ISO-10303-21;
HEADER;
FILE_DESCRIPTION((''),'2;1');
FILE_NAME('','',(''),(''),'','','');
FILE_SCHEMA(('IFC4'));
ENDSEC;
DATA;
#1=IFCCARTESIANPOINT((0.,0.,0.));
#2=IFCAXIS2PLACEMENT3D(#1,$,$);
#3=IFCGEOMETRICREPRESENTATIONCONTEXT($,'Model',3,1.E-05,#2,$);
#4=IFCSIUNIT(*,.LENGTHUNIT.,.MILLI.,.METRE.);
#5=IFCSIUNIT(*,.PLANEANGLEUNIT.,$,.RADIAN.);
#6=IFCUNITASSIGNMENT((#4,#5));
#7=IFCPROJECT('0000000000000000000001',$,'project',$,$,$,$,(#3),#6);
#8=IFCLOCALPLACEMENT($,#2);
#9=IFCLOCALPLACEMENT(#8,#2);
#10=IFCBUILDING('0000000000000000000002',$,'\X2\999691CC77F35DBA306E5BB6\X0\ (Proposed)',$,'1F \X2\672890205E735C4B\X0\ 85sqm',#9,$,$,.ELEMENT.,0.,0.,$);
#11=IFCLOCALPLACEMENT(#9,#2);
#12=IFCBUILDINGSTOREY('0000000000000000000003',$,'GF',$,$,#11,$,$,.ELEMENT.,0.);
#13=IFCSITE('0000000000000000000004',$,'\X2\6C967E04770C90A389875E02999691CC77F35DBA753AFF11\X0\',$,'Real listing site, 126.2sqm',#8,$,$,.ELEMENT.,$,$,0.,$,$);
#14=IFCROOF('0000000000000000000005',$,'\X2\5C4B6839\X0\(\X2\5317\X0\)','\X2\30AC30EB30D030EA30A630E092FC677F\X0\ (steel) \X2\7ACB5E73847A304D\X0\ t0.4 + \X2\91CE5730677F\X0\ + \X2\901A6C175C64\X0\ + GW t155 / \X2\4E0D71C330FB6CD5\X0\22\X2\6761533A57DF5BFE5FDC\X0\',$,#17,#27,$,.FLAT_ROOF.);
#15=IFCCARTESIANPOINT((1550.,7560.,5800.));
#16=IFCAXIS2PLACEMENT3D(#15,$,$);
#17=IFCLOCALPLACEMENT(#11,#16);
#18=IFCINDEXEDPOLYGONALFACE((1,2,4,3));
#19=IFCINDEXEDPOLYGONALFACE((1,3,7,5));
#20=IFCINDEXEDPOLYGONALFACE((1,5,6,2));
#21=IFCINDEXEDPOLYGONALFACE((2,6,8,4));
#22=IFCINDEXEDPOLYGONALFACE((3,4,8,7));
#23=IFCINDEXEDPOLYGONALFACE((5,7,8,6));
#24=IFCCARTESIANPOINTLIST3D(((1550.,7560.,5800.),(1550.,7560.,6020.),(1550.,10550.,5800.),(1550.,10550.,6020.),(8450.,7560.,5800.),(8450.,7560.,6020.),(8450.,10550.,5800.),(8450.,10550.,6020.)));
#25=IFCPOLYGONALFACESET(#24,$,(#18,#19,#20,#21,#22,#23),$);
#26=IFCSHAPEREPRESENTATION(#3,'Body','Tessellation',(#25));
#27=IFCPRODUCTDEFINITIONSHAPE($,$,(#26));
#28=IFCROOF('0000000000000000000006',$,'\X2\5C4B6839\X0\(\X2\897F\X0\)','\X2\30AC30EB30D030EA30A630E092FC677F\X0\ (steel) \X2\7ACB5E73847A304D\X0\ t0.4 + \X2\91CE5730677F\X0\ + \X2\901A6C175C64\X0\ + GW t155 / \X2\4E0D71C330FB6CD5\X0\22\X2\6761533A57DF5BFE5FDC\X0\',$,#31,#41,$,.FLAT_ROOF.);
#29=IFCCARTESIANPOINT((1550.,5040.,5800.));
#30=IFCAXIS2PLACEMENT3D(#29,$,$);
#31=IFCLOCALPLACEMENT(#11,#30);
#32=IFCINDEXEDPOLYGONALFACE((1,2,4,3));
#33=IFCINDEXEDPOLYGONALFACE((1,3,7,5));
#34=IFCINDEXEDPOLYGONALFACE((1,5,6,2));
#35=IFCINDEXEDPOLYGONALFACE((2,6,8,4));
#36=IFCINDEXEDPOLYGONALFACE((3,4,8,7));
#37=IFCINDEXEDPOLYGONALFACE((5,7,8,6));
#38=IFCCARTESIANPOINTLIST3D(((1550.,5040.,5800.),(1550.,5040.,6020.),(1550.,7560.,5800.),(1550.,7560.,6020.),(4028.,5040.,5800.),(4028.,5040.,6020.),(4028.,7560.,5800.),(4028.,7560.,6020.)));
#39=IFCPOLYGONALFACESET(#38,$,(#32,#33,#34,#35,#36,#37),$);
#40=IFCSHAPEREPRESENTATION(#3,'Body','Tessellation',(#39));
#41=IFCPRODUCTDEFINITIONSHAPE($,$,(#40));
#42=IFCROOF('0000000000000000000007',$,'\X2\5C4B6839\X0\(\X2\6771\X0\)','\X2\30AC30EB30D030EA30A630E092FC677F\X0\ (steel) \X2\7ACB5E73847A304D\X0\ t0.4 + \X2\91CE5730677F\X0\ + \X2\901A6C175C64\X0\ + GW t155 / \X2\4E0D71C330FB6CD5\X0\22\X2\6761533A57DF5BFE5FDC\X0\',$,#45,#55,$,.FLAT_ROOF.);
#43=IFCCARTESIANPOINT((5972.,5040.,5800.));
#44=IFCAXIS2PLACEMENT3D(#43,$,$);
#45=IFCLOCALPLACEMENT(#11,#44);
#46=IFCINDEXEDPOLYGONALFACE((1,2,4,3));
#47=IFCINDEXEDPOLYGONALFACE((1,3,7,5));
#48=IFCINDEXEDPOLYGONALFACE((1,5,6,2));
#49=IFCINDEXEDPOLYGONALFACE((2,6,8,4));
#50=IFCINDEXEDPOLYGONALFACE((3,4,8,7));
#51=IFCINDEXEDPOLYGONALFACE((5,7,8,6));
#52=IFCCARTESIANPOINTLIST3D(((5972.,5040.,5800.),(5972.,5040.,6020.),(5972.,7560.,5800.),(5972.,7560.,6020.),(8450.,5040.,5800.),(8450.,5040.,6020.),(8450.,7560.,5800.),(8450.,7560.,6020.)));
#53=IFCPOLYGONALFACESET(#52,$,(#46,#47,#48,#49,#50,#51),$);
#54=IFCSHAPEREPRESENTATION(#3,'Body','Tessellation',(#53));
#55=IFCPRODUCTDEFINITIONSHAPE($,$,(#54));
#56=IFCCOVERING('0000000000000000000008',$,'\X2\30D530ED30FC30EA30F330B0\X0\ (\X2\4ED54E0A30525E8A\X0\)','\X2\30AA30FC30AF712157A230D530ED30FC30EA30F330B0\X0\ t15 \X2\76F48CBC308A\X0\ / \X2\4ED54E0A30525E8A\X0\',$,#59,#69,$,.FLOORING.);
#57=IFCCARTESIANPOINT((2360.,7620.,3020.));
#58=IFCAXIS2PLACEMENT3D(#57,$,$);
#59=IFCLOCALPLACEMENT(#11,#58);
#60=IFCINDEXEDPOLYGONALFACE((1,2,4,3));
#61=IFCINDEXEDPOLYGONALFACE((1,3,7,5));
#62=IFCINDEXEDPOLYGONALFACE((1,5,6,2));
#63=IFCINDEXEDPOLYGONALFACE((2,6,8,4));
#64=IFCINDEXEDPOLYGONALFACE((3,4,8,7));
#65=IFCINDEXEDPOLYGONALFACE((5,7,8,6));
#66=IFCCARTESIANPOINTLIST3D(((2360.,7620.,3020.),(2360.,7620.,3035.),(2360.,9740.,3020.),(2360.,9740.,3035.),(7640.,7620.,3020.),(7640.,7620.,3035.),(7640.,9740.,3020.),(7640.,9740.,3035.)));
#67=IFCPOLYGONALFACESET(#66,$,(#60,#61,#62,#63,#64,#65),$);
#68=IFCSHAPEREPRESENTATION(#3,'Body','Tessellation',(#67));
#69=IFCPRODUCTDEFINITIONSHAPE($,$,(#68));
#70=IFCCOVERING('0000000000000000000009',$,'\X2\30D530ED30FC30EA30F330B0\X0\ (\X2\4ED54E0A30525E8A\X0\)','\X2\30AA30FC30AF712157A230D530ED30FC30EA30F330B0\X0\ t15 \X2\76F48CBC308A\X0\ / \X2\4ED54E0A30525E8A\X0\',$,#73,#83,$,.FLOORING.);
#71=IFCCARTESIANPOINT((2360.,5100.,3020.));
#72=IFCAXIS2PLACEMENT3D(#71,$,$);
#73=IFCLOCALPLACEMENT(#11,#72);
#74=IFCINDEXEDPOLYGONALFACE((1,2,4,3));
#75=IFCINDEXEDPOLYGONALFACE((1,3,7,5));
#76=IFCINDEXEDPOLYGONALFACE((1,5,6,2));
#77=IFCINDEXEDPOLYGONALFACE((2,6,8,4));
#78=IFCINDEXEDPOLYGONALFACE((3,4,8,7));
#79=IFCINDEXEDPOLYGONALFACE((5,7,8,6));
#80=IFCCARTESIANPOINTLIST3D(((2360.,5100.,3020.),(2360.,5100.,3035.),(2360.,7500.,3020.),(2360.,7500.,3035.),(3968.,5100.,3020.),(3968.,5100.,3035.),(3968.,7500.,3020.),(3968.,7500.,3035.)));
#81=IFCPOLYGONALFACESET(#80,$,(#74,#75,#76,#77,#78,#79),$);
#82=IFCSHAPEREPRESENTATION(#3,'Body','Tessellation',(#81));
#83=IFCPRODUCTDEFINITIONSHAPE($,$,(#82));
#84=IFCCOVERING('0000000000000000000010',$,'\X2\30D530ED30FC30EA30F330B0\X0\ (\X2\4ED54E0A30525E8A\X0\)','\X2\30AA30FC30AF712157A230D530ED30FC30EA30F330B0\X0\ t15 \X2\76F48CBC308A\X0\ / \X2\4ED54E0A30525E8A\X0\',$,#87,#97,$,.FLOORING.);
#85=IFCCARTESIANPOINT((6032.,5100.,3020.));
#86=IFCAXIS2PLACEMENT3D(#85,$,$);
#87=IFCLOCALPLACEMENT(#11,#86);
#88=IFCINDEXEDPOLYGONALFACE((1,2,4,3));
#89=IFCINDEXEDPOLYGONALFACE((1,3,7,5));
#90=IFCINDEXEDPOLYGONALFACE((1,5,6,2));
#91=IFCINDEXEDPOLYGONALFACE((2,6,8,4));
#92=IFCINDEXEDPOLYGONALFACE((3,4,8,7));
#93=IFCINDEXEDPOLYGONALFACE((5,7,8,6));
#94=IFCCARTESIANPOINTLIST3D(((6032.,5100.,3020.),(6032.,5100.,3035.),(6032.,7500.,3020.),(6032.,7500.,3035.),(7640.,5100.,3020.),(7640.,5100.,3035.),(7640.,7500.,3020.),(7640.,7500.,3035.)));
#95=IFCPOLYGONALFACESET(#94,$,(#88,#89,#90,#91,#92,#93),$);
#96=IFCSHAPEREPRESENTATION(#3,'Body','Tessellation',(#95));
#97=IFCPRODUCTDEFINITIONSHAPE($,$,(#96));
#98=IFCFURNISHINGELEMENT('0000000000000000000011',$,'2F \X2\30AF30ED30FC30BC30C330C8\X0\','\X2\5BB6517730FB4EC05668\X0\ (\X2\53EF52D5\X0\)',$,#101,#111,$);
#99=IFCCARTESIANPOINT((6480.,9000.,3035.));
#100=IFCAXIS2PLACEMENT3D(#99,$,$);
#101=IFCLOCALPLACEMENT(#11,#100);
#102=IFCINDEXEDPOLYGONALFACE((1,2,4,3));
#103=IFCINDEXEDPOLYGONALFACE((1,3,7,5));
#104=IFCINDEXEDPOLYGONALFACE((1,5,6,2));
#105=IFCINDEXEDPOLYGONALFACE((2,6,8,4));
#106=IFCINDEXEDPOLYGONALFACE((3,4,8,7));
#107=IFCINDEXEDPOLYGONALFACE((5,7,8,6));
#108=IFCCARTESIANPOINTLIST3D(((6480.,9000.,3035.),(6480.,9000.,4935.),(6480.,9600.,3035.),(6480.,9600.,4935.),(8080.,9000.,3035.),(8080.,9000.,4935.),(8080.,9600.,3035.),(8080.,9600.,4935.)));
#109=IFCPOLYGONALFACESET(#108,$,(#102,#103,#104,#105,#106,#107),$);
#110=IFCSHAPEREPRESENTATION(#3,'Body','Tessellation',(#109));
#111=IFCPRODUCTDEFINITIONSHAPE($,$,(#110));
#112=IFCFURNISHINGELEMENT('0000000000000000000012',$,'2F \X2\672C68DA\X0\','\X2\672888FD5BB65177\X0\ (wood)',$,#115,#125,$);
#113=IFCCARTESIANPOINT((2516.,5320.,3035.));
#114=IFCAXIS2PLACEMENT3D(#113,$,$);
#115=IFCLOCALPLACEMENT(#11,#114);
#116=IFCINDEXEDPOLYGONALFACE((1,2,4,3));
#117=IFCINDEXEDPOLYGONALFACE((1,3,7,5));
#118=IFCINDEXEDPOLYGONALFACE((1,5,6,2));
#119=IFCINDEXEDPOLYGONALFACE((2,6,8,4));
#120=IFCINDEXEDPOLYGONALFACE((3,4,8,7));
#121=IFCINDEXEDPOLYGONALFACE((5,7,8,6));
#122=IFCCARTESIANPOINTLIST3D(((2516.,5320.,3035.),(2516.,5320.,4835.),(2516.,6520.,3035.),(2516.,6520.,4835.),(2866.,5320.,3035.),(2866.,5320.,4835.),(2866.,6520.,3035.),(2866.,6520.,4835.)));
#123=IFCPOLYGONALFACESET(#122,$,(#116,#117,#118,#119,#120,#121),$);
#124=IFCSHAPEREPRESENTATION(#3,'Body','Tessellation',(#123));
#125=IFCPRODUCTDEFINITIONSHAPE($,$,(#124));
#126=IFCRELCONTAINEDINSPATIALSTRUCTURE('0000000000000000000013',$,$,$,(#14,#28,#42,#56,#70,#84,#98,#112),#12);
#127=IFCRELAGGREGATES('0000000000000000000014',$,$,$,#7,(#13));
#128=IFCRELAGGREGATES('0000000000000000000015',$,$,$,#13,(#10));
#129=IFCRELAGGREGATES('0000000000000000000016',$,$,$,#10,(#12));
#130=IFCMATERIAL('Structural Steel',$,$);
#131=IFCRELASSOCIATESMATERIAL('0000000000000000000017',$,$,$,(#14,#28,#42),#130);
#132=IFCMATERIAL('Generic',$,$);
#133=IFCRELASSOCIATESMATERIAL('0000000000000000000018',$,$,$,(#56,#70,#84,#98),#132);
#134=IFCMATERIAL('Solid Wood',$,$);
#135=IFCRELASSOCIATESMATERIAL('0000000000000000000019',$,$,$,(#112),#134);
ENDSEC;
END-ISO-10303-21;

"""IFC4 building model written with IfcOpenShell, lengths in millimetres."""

from ifc_helpers import new_model, si_unit, frame, frame_2d, origin, place, context, project, spatial, rectangle, extrude, material, element, save


model = new_model("IFC4")

# Units and contexts
model_context = context("Model", 3, precision=1e-05, world=origin())
ifc_project = project(units=[si_unit("LENGTHUNIT", "METRE", prefix="MILLI"), si_unit("PLANEANGLEUNIT", "RADIAN")], contexts=[model_context])

# Site, building, storey
site_placement = place(None, origin())
site = spatial("IfcSite", under=ifc_project, at=site_placement, Name="沖縄県那覇市首里石嶺町１", ObjectType="Real listing site, 126.2sqm", CompositionType="ELEMENT", RefElevation=0.0)
building_placement = place(site_placement, origin())
building = spatial("IfcBuilding", under=site, at=building_placement, Name="首里石嶺の家 (Proposed)", ObjectType="1F 木造平屋 85sqm", CompositionType="ELEMENT", ElevationOfRefHeight=0.0, ElevationOfTerrain=0.0)
storey_placement = place(building_placement, origin())
storey = spatial("IfcBuildingStorey", under=building, at=storey_placement, Name="GF", CompositionType="ELEMENT", Elevation=0.0)

# Shared definitions
ifc_material_1 = material(Name="Solid Wood")

# Shared definitions
ifc_material_2 = material(Name="Generic")

# Roofs
ifc_material_3 = material(Name="Structural Steel")
for number, where, name in (
    (1, (1550.0, 7560.0, 5800.0), "屋根(北)"),
):
    element("IfcRoof", number, at=place(storey_placement, frame(where)), inside=storey, material=ifc_material_3, Name=name, Description="ガルバリウム鋼板 (steel) 立平葺き t0.4 + 野地板 + 通気層 + GW t155 / 不燃・法22条区域対応", PredefinedType="FLAT_ROOF", context=model_context, shape_type="SweptSolid", body=[
        extrude(rectangle(XDim=6900.0, YDim=2990.0, at=frame_2d((3450.0, 1495.0))), frame((1550.0, 7560.0, 5800.0)), (0.0, 0.0, 1.0), 220.0),
    ])
roof_1_placement = place(storey_placement, frame((1550.0, 5040.0, 5800.0)))
element("IfcRoof", 2, at=roof_1_placement, inside=storey, material=ifc_material_3, Name="屋根(西)", Description="ガルバリウム鋼板 (steel) 立平葺き t0.4 + 野地板 + 通気層 + GW t155 / 不燃・法22条区域対応", PredefinedType="FLAT_ROOF", context=model_context, shape_type="SweptSolid", body=[
    extrude(rectangle(XDim=2478.0, YDim=2520.0, at=frame_2d((1239.0, 1260.0))), frame((1550.0, 5040.0, 5800.0)), (0.0, 0.0, 1.0), 220.0),
])
roof_2_placement = place(storey_placement, frame((5972.0, 5040.0, 5800.0)))
element("IfcRoof", 3, at=roof_2_placement, inside=storey, material=ifc_material_3, Name="屋根(東)", Description="ガルバリウム鋼板 (steel) 立平葺き t0.4 + 野地板 + 通気層 + GW t155 / 不燃・法22条区域対応", PredefinedType="FLAT_ROOF", context=model_context, shape_type="SweptSolid", body=[
    extrude(rectangle(XDim=2478.0, YDim=2520.0, at=frame_2d((1239.0, 1260.0))), frame((5972.0, 5040.0, 5800.0)), (0.0, 0.0, 1.0), 220.0),
])

# Coverings
covering_1_placement = place(storey_placement, frame((2360.0, 7620.0, 3020.0)))
element("IfcCovering", 4, at=covering_1_placement, inside=storey, material=ifc_material_2, Name="フローリング (仕上げ床)", Description="オーク無垢フローリング t15 直貼り / 仕上げ床", PredefinedType="FLOORING", context=model_context, shape_type="SweptSolid", body=[
    extrude(rectangle(XDim=5280.0, YDim=2120.0, at=frame_2d((2640.0, 1060.0))), frame((2360.0, 7620.0, 3020.0)), (0.0, 0.0, 1.0), 15.0),
])
covering_2_placement = place(storey_placement, frame((2360.0, 5100.0, 3020.0)))
element("IfcCovering", 5, at=covering_2_placement, inside=storey, material=ifc_material_2, Name="フローリング (仕上げ床)", Description="オーク無垢フローリング t15 直貼り / 仕上げ床", PredefinedType="FLOORING", context=model_context, shape_type="SweptSolid", body=[
    extrude(rectangle(XDim=1608.0, YDim=2400.0, at=frame_2d((804.0, 1200.0))), frame((2360.0, 5100.0, 3020.0)), (0.0, 0.0, 1.0), 15.0),
])
covering_3_placement = place(storey_placement, frame((6032.0, 5100.0, 3020.0)))
element("IfcCovering", 6, at=covering_3_placement, inside=storey, material=ifc_material_2, Name="フローリング (仕上げ床)", Description="オーク無垢フローリング t15 直貼り / 仕上げ床", PredefinedType="FLOORING", context=model_context, shape_type="SweptSolid", body=[
    extrude(rectangle(XDim=1608.0, YDim=2400.0, at=frame_2d((804.0, 1200.0))), frame((6032.0, 5100.0, 3020.0)), (0.0, 0.0, 1.0), 15.0),
])

# Furnishing elements
furnishing_1_placement = place(storey_placement, frame((6480.0, 9000.0, 3035.0)))
element("IfcFurnishingElement", 7, at=furnishing_1_placement, inside=storey, material=ifc_material_2, Name="2F クローゼット", Description="家具・什器 (可動)", context=model_context, shape_type="SweptSolid", body=[
    extrude(rectangle(XDim=1600.0, YDim=600.0, at=frame_2d((800.0, 300.0))), frame((6480.0, 9000.0, 3035.0)), (0.0, 0.0, 1.0), 1900.0),
])
furnishing_2_placement = place(storey_placement, frame((2516.0, 5320.0, 3035.0)))
element("IfcFurnishingElement", 8, at=furnishing_2_placement, inside=storey, material=ifc_material_1, Name="2F 本棚", Description="木製家具 (wood)", context=model_context, shape_type="SweptSolid", body=[
    extrude(rectangle(XDim=350.0, YDim=1200.0, at=frame_2d((175.0, 600.0))), frame((2516.0, 5320.0, 3035.0)), (0.0, 0.0, 1.0), 1800.0),
])

save(model, "model.ifc")
